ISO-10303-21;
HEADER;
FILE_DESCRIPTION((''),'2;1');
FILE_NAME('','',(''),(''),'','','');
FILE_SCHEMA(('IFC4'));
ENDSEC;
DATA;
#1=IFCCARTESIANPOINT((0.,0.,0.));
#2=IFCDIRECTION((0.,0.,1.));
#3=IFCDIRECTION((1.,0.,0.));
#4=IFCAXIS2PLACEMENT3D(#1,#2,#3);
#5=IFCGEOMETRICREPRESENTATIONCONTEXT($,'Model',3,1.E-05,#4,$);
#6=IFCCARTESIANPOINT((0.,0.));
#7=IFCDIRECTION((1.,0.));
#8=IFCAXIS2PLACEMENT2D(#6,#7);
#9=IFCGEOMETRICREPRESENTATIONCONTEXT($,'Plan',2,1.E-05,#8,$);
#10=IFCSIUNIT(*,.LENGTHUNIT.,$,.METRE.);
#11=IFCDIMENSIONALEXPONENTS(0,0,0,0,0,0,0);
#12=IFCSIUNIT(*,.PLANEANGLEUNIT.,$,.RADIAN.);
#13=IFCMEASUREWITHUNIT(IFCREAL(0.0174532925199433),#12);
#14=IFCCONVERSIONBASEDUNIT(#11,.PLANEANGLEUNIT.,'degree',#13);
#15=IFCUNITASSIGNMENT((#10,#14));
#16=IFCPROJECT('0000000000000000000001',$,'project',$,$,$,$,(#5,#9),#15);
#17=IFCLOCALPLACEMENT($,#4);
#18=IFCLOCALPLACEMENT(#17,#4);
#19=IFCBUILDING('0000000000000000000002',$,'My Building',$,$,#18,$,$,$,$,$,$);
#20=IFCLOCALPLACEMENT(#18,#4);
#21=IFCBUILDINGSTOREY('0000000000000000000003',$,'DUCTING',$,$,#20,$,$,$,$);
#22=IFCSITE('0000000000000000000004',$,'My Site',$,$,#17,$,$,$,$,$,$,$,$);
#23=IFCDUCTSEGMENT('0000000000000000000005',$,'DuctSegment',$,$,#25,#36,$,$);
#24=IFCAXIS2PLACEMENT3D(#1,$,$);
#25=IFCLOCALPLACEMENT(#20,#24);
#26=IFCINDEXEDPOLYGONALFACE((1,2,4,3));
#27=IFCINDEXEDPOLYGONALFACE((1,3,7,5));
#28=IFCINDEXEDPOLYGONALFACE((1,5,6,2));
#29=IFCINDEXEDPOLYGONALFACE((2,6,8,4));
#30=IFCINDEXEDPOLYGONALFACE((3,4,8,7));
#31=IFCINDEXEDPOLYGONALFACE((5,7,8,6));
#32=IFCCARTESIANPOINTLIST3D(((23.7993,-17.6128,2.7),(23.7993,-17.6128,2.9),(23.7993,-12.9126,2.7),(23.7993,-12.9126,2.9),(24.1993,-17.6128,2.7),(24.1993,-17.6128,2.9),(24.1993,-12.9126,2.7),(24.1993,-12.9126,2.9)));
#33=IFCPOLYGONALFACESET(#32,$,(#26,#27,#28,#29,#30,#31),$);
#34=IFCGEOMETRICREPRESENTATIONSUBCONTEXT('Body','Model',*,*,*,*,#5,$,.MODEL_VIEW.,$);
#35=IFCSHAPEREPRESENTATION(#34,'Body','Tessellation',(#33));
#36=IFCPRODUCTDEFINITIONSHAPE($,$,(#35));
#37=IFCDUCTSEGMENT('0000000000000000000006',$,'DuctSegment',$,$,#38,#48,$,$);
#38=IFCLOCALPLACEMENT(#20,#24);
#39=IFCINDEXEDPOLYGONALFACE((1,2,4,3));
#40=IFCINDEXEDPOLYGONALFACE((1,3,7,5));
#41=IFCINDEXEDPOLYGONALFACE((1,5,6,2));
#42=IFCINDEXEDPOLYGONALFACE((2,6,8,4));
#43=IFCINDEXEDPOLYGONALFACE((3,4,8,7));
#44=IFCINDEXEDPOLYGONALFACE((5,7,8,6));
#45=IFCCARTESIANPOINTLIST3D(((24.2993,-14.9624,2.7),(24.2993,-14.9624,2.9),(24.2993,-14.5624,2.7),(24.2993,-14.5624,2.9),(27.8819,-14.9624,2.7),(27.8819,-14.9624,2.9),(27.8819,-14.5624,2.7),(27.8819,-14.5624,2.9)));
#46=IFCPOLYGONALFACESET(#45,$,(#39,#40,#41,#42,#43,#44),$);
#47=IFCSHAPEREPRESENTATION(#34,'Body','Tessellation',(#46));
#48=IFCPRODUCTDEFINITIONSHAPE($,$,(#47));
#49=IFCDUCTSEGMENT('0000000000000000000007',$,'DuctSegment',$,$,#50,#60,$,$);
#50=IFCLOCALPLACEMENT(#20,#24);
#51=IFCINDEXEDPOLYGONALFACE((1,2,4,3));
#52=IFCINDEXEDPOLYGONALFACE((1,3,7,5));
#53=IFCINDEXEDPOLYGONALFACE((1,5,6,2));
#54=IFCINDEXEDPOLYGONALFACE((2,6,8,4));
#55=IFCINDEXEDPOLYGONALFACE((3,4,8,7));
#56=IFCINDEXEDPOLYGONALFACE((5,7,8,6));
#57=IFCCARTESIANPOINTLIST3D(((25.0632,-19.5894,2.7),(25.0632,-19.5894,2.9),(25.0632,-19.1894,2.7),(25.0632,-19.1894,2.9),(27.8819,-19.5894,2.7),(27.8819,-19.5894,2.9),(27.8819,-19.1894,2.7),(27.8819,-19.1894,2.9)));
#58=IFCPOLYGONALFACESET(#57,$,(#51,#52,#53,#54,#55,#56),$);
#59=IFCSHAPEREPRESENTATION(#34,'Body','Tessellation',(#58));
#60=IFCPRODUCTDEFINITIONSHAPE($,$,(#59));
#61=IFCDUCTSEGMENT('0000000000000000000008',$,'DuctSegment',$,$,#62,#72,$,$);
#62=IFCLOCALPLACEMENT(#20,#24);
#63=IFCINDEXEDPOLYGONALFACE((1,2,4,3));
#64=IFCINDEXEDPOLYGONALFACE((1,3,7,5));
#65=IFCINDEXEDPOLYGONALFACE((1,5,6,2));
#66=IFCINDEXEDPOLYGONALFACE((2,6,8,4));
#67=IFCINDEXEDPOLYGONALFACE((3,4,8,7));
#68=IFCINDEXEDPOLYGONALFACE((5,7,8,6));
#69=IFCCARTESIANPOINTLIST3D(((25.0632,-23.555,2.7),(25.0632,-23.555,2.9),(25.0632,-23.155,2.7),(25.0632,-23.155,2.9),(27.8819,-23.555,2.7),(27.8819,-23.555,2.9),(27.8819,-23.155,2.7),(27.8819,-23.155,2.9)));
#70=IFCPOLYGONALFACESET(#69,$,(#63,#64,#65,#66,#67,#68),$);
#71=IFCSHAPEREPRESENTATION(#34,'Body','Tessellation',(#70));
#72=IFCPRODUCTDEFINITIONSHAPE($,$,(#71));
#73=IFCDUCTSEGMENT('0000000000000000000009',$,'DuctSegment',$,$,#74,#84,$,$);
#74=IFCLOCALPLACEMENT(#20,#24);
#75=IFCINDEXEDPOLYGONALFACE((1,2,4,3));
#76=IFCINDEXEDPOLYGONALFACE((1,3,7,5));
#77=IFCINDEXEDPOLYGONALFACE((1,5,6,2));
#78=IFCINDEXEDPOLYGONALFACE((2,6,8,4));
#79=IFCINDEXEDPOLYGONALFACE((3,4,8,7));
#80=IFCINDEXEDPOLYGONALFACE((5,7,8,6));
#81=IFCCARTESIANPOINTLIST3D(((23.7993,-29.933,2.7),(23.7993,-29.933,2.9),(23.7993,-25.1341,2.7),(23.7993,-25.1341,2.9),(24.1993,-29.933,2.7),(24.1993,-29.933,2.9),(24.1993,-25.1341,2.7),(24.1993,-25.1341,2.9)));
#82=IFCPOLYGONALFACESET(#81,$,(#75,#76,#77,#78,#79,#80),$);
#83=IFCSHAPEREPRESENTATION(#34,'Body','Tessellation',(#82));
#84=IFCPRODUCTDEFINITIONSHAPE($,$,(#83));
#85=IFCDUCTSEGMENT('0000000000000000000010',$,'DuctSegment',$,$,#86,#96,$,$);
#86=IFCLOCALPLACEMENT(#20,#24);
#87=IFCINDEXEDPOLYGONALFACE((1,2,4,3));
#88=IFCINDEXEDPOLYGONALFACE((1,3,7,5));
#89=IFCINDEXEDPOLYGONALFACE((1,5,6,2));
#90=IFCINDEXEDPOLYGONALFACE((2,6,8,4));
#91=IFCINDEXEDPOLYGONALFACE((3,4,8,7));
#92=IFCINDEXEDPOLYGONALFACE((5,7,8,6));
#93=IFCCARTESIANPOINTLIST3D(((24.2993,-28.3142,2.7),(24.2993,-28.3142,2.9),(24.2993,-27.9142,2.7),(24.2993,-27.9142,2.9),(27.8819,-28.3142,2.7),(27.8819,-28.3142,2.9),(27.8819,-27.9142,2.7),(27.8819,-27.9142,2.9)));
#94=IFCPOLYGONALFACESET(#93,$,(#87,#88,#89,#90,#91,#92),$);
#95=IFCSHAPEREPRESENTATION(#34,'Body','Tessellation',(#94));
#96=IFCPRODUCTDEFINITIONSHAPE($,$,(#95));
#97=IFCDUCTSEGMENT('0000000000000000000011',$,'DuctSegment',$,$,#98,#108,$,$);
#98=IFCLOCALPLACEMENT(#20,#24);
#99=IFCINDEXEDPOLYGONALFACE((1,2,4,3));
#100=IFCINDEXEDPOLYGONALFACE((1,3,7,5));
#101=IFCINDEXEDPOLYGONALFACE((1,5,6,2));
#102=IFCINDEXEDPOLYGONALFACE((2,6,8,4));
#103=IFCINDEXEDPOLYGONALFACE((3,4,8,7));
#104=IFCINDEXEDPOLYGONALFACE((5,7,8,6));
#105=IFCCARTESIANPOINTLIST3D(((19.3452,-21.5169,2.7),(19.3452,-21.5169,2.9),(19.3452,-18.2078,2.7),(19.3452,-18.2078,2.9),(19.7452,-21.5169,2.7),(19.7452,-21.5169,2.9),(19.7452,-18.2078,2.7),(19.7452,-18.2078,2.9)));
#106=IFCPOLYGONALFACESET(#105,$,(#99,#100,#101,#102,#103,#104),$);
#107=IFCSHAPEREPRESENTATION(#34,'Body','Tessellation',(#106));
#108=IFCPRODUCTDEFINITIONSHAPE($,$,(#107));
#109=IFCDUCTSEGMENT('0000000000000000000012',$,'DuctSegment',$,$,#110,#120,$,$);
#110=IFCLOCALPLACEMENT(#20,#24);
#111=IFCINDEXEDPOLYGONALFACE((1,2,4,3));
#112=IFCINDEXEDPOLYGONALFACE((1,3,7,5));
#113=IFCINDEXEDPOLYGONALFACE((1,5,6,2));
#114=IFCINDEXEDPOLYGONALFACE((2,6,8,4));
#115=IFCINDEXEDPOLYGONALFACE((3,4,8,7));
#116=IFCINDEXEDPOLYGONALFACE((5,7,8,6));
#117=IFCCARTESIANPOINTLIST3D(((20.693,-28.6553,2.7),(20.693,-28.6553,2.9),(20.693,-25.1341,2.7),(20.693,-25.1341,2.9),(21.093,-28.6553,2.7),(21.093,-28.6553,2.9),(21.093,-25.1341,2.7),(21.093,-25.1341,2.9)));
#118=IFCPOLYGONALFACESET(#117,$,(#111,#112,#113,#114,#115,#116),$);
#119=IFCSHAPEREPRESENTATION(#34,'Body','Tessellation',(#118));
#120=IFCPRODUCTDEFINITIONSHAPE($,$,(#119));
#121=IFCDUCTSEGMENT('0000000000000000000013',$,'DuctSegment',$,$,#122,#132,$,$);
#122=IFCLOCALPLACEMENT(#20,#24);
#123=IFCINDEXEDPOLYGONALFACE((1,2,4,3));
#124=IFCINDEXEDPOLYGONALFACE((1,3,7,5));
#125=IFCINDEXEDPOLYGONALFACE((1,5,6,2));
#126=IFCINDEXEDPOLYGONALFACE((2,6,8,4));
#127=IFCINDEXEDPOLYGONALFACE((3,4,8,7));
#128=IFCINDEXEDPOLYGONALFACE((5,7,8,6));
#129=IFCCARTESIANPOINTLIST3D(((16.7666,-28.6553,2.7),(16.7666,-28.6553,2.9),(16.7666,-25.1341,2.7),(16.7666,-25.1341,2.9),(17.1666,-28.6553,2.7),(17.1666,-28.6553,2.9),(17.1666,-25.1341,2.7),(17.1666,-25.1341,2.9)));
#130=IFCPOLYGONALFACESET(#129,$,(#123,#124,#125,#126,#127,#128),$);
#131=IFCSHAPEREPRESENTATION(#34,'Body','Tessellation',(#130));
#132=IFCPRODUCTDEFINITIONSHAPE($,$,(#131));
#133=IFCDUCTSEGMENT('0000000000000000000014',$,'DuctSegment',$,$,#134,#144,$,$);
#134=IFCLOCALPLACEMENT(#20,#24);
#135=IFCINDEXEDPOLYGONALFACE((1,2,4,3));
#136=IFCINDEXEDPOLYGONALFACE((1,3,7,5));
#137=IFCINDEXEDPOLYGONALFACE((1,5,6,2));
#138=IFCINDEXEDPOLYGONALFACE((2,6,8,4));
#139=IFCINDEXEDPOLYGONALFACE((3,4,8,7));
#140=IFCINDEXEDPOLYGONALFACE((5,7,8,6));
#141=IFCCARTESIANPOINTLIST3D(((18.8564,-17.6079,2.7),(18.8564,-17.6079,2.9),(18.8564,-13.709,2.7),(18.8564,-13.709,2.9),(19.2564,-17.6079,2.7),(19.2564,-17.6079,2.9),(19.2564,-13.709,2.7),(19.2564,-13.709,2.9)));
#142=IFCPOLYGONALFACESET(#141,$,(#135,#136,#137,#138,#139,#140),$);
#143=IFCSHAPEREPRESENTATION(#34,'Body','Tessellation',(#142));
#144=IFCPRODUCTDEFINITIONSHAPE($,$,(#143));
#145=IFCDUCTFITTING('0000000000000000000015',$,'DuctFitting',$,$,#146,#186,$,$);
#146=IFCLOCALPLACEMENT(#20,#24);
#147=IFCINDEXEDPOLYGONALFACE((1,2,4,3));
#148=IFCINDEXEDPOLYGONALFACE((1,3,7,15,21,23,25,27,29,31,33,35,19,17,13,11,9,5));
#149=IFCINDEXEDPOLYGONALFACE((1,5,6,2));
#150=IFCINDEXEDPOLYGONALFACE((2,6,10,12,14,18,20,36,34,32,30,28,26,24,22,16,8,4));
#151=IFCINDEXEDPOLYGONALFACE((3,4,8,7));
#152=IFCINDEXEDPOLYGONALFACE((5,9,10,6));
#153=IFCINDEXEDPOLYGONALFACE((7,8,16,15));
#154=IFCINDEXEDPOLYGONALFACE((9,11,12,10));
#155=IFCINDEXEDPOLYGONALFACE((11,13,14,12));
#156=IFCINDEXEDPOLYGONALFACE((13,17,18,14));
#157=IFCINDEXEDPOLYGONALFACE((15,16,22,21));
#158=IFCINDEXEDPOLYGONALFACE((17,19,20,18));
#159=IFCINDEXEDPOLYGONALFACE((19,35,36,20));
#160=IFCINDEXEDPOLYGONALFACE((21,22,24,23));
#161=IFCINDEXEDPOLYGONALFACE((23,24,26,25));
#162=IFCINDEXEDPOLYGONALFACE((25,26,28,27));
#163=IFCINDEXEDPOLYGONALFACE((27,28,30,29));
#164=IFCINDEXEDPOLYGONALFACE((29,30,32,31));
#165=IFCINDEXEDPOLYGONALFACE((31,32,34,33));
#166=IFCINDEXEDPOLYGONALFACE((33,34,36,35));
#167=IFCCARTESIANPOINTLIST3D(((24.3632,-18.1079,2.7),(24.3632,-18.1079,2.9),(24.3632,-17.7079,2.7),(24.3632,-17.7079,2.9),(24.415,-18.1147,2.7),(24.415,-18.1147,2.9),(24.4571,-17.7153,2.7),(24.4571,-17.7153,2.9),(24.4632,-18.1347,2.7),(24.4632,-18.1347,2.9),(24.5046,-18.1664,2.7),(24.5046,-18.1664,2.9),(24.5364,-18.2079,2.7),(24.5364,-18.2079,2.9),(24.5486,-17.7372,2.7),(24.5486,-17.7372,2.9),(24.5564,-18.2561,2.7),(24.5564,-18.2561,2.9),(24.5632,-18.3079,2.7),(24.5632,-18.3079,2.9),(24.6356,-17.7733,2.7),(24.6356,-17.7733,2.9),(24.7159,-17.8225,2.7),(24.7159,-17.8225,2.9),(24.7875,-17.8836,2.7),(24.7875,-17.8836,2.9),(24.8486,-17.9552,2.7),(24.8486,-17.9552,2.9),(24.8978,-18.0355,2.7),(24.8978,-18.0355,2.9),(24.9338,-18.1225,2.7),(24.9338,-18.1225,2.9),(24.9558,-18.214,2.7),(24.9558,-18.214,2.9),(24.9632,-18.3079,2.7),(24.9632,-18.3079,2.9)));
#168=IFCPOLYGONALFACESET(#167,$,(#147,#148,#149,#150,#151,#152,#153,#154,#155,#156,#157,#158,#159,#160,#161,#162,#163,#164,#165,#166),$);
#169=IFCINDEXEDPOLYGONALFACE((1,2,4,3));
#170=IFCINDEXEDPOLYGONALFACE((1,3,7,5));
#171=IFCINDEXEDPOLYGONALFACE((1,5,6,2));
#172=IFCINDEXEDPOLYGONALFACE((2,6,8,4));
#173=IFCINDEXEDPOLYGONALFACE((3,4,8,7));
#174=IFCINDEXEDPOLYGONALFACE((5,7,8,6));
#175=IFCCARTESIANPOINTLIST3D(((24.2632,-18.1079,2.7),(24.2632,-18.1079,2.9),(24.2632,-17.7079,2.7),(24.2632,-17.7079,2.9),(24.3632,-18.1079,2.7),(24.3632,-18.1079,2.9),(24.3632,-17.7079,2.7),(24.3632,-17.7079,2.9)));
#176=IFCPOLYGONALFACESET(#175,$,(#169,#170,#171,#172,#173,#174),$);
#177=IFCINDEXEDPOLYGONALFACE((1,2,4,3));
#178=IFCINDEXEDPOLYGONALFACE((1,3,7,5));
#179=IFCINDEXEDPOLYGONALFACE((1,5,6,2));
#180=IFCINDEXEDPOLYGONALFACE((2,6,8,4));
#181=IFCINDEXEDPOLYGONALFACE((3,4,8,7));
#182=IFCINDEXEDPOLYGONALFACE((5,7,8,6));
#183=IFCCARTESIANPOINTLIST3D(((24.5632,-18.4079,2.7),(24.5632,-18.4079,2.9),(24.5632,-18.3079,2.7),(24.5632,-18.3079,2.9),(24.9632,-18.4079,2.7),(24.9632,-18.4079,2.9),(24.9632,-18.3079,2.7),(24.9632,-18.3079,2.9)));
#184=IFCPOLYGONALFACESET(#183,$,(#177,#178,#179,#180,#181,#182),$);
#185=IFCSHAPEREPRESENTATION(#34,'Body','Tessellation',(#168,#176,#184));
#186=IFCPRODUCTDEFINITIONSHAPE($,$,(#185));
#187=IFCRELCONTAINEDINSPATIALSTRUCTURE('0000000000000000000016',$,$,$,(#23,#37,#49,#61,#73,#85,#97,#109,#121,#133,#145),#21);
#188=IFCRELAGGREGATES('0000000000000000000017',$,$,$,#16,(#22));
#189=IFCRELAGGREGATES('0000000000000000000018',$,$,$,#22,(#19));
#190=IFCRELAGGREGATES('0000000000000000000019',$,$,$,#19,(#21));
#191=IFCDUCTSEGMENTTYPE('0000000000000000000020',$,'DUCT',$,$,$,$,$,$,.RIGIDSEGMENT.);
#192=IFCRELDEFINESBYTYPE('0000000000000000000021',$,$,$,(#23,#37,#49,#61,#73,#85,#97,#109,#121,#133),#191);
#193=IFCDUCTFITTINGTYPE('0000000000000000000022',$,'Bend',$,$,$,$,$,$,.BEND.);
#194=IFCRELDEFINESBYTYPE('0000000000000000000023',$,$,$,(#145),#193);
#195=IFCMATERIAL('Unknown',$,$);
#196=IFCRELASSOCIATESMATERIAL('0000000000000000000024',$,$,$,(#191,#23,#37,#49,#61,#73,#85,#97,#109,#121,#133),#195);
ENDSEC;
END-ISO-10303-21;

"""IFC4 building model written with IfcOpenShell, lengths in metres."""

from ifc_helpers import new_model, entity, si_unit, converted_unit, frame, origin_with_axes, origin_2d_with_axis, place, context, subcontext, project, spatial, line, arc, indexed_curve, rectangle, outline, extrude, source, transform, mapped, material, material_profile, profile_set, profile_usage, type_object, type_shapes, element, save


model = new_model("IFC4")

# Units and contexts
model_context = context("Model", 3, precision=1e-05, world=origin_with_axes())
plan_context = context("Plan", 2, precision=1e-05, world=origin_2d_with_axis())
body_context = subcontext(model_context, "Body", "Model", "MODEL_VIEW")
ifc_project = project(units=[si_unit("LENGTHUNIT", "METRE"), converted_unit("PLANEANGLEUNIT", "degree", entity("IfcReal", 0.0174532925199433), si_unit("PLANEANGLEUNIT", "RADIAN"), dimensions=[0, 0, 0, 0, 0, 0, 0])], contexts=[model_context, plan_context])

# Site, building, storey
site_placement = place(None, origin_with_axes())
site = spatial("IfcSite", under=ifc_project, at=site_placement, Name="My Site")
building_placement = place(site_placement, origin_with_axes())
building = spatial("IfcBuilding", under=site, at=building_placement, Name="My Building")
storey_placement = place(building_placement, origin_with_axes())
storey = spatial("IfcBuildingStorey", under=building, at=storey_placement, Name="DUCTING")

# Duct segments
ifc_material = material(Name="Unknown")
ifc_material_profile_1 = material_profile(ifc_material, rectangle(XDim=0.4, YDim=0.2))
ifc_profile_set_1 = profile_set([ifc_material_profile_1])
ifc_profile_usage_1 = profile_usage(ifc_profile_set_1, cardinal=5)
duct_segment_type = type_object("IfcDuctSegmentType", Name="DUCT", PredefinedType="RIGIDSEGMENT", material=ifc_profile_set_1)
duct_segment_1_placement = place(storey_placement, frame((23.9993, -12.9126, 2.8), z_axis=(0.0, -1.0, 0.0), x_axis=(1.0, 0.0, 0.0)))
element("IfcDuctSegment", 1, at=duct_segment_1_placement, inside=storey, type_object=duct_segment_type, material=ifc_profile_usage_1, Name="DuctSegment", context=body_context, shape_type="SweptSolid", body=[
    extrude(rectangle(XDim=0.4, YDim=0.2), origin_with_axes(), (0.0, 0.0, 1.0), 4.7002),
])
ifc_profile_usage_2 = profile_usage(ifc_profile_set_1, cardinal=5)
duct_segment_2_placement = place(storey_placement, frame((27.8819, -14.7624, 2.8), z_axis=(-1.0, 0.0, 0.0), x_axis=(0.0, -1.0, 0.0)))
element("IfcDuctSegment", 2, at=duct_segment_2_placement, inside=storey, type_object=duct_segment_type, material=ifc_profile_usage_2, Name="DuctSegment", context=body_context, shape_type="SweptSolid", body=[
    extrude(rectangle(XDim=0.4, YDim=0.2), origin_with_axes(), (0.0, 0.0, 1.0), 3.5826),
])
ifc_profile_usage_3 = profile_usage(ifc_profile_set_1, cardinal=5)
duct_segment_3_placement = place(storey_placement, frame((27.8819, -19.3894, 2.8), z_axis=(-1.0, 0.0, 0.0), x_axis=(0.0, -1.0, 0.0)))
element("IfcDuctSegment", 3, at=duct_segment_3_placement, inside=storey, type_object=duct_segment_type, material=ifc_profile_usage_3, Name="DuctSegment", context=body_context, shape_type="SweptSolid", body=[
    extrude(rectangle(XDim=0.4, YDim=0.2), origin_with_axes(), (0.0, 0.0, 1.0), 2.8187),
])
ifc_profile_usage_4 = profile_usage(ifc_profile_set_1, cardinal=5)
duct_segment_4_placement = place(storey_placement, frame((27.8819, -23.355, 2.8), z_axis=(-1.0, 0.0, 0.0), x_axis=(0.0, -1.0, 0.0)))
element("IfcDuctSegment", 4, at=duct_segment_4_placement, inside=storey, type_object=duct_segment_type, material=ifc_profile_usage_4, Name="DuctSegment", context=body_context, shape_type="SweptSolid", body=[
    extrude(rectangle(XDim=0.4, YDim=0.2), origin_with_axes(), (0.0, 0.0, 1.0), 2.8187),
])
ifc_profile_usage_5 = profile_usage(ifc_profile_set_1, cardinal=5)
duct_segment_5_placement = place(storey_placement, frame((23.9993, -29.933, 2.8), z_axis=(0.0, 1.0, 0.0), x_axis=(-1.0, 0.0, 0.0)))
element("IfcDuctSegment", 5, at=duct_segment_5_placement, inside=storey, type_object=duct_segment_type, material=ifc_profile_usage_5, Name="DuctSegment", context=body_context, shape_type="SweptSolid", body=[
    extrude(rectangle(XDim=0.4, YDim=0.2), origin_with_axes(), (0.0, 0.0, 1.0), 4.7989),
])
ifc_profile_usage_6 = profile_usage(ifc_profile_set_1, cardinal=5)
duct_segment_6_placement = place(storey_placement, frame((27.8819, -28.1142, 2.8), z_axis=(-1.0, 0.0, 0.0), x_axis=(0.0, -1.0, 0.0)))
element("IfcDuctSegment", 6, at=duct_segment_6_placement, inside=storey, type_object=duct_segment_type, material=ifc_profile_usage_6, Name="DuctSegment", context=body_context, shape_type="SweptSolid", body=[
    extrude(rectangle(XDim=0.4, YDim=0.2), origin_with_axes(), (0.0, 0.0, 1.0), 3.5826),
])
ifc_profile_usage_7 = profile_usage(ifc_profile_set_1, cardinal=5)
duct_segment_7_placement = place(storey_placement, frame((19.5452, -21.5169, 2.8), z_axis=(0.0, 1.0, 0.0), x_axis=(-1.0, 0.0, 0.0)))
element("IfcDuctSegment", 7, at=duct_segment_7_placement, inside=storey, type_object=duct_segment_type, material=ifc_profile_usage_7, Name="DuctSegment", context=body_context, shape_type="SweptSolid", body=[
    extrude(rectangle(XDim=0.4, YDim=0.2), origin_with_axes(), (0.0, 0.0, 1.0), 3.309),
])
ifc_profile_usage_8 = profile_usage(ifc_profile_set_1, cardinal=5)
duct_segment_8_placement = place(storey_placement, frame((20.893, -28.6553, 2.8), z_axis=(0.0, 1.0, 0.0), x_axis=(-1.0, 0.0, 0.0)))
element("IfcDuctSegment", 8, at=duct_segment_8_placement, inside=storey, type_object=duct_segment_type, material=ifc_profile_usage_8, Name="DuctSegment", context=body_context, shape_type="SweptSolid", body=[
    extrude(rectangle(XDim=0.4, YDim=0.2), origin_with_axes(), (0.0, 0.0, 1.0), 3.5212),
])
ifc_profile_usage_9 = profile_usage(ifc_profile_set_1, cardinal=5)
duct_segment_9_placement = place(storey_placement, frame((16.9666, -28.6553, 2.8), z_axis=(0.0, 1.0, 0.0), x_axis=(-1.0, 0.0, 0.0)))
element("IfcDuctSegment", 9, at=duct_segment_9_placement, inside=storey, type_object=duct_segment_type, material=ifc_profile_usage_9, Name="DuctSegment", context=body_context, shape_type="SweptSolid", body=[
    extrude(rectangle(XDim=0.4, YDim=0.2), origin_with_axes(), (0.0, 0.0, 1.0), 3.5212),
])
ifc_profile_usage_10 = profile_usage(ifc_profile_set_1, cardinal=5)
duct_segment_10_placement = place(storey_placement, frame((19.0564, -13.709, 2.8), z_axis=(0.0, -1.0, 0.0), x_axis=(1.0, 0.0, 0.0)))
element("IfcDuctSegment", 10, at=duct_segment_10_placement, inside=storey, type_object=duct_segment_type, material=ifc_profile_usage_10, Name="DuctSegment", context=body_context, shape_type="SweptSolid", body=[
    extrude(rectangle(XDim=0.4, YDim=0.2), origin_with_axes(), (0.0, 0.0, 1.0), 3.8989),
])

# Duct fitting
duct_fitting_type_1 = type_object("IfcDuctFittingType", Name="Bend", PredefinedType="BEND")
shared_shape = source(origin_with_axes(), body_context, "Body", "SweptSolid", [
    extrude(outline(indexed_curve([(-0.2, 0.0), (-0.2586, 0.1414), (-0.4, 0.2), (-0.4, 0.6), (0.0243, 0.4243), (0.2, 0.0)], segments=[arc(1, 2, 3), line(3, 4), arc(4, 5, 6), line(6, 1)])), frame((0.0, -0.1, 0.1), z_axis=(0.0, -1.0, 0.0), x_axis=(1.0, 0.0, 0.0)), (0.0, 0.0, -1.0), 0.2),
    extrude(rectangle(XDim=0.4, YDim=0.2), origin_with_axes(), (0.0, 0.0, 1.0), 0.1),
    extrude(rectangle(XDim=0.4, YDim=0.2), frame((-0.4, 0.0, 0.5), z_axis=(-1.0, 0.0, 0.0), x_axis=(0.0, 0.0, -1.0)), (0.0, 0.0, 1.0), 0.1),
])
type_shapes(duct_fitting_type_1, [shared_shape])
for number, where, z_axis, x_axis, name in (
    (11, (24.2632, -17.9079, 2.8), (1.0, 0.0, 0.0), (0.0, 1.0, 0.0), "DuctFitting"),
):
    element("IfcDuctFitting", number, at=place(storey_placement, frame(where, z_axis=z_axis, x_axis=x_axis)), inside=storey, type_object=duct_fitting_type_1, Name=name, context=body_context, shape_type="MappedRepresentation", body=[
        mapped(shared_shape, transform((0.0, 0.0, 0.0), x_axis=(1.0, 0.0, 0.0), y_axis=(0.0, 1.0, 0.0), z_axis=(0.0, 0.0, 1.0), scale=1.0)),
    ])

save(model, "model.ifc")
